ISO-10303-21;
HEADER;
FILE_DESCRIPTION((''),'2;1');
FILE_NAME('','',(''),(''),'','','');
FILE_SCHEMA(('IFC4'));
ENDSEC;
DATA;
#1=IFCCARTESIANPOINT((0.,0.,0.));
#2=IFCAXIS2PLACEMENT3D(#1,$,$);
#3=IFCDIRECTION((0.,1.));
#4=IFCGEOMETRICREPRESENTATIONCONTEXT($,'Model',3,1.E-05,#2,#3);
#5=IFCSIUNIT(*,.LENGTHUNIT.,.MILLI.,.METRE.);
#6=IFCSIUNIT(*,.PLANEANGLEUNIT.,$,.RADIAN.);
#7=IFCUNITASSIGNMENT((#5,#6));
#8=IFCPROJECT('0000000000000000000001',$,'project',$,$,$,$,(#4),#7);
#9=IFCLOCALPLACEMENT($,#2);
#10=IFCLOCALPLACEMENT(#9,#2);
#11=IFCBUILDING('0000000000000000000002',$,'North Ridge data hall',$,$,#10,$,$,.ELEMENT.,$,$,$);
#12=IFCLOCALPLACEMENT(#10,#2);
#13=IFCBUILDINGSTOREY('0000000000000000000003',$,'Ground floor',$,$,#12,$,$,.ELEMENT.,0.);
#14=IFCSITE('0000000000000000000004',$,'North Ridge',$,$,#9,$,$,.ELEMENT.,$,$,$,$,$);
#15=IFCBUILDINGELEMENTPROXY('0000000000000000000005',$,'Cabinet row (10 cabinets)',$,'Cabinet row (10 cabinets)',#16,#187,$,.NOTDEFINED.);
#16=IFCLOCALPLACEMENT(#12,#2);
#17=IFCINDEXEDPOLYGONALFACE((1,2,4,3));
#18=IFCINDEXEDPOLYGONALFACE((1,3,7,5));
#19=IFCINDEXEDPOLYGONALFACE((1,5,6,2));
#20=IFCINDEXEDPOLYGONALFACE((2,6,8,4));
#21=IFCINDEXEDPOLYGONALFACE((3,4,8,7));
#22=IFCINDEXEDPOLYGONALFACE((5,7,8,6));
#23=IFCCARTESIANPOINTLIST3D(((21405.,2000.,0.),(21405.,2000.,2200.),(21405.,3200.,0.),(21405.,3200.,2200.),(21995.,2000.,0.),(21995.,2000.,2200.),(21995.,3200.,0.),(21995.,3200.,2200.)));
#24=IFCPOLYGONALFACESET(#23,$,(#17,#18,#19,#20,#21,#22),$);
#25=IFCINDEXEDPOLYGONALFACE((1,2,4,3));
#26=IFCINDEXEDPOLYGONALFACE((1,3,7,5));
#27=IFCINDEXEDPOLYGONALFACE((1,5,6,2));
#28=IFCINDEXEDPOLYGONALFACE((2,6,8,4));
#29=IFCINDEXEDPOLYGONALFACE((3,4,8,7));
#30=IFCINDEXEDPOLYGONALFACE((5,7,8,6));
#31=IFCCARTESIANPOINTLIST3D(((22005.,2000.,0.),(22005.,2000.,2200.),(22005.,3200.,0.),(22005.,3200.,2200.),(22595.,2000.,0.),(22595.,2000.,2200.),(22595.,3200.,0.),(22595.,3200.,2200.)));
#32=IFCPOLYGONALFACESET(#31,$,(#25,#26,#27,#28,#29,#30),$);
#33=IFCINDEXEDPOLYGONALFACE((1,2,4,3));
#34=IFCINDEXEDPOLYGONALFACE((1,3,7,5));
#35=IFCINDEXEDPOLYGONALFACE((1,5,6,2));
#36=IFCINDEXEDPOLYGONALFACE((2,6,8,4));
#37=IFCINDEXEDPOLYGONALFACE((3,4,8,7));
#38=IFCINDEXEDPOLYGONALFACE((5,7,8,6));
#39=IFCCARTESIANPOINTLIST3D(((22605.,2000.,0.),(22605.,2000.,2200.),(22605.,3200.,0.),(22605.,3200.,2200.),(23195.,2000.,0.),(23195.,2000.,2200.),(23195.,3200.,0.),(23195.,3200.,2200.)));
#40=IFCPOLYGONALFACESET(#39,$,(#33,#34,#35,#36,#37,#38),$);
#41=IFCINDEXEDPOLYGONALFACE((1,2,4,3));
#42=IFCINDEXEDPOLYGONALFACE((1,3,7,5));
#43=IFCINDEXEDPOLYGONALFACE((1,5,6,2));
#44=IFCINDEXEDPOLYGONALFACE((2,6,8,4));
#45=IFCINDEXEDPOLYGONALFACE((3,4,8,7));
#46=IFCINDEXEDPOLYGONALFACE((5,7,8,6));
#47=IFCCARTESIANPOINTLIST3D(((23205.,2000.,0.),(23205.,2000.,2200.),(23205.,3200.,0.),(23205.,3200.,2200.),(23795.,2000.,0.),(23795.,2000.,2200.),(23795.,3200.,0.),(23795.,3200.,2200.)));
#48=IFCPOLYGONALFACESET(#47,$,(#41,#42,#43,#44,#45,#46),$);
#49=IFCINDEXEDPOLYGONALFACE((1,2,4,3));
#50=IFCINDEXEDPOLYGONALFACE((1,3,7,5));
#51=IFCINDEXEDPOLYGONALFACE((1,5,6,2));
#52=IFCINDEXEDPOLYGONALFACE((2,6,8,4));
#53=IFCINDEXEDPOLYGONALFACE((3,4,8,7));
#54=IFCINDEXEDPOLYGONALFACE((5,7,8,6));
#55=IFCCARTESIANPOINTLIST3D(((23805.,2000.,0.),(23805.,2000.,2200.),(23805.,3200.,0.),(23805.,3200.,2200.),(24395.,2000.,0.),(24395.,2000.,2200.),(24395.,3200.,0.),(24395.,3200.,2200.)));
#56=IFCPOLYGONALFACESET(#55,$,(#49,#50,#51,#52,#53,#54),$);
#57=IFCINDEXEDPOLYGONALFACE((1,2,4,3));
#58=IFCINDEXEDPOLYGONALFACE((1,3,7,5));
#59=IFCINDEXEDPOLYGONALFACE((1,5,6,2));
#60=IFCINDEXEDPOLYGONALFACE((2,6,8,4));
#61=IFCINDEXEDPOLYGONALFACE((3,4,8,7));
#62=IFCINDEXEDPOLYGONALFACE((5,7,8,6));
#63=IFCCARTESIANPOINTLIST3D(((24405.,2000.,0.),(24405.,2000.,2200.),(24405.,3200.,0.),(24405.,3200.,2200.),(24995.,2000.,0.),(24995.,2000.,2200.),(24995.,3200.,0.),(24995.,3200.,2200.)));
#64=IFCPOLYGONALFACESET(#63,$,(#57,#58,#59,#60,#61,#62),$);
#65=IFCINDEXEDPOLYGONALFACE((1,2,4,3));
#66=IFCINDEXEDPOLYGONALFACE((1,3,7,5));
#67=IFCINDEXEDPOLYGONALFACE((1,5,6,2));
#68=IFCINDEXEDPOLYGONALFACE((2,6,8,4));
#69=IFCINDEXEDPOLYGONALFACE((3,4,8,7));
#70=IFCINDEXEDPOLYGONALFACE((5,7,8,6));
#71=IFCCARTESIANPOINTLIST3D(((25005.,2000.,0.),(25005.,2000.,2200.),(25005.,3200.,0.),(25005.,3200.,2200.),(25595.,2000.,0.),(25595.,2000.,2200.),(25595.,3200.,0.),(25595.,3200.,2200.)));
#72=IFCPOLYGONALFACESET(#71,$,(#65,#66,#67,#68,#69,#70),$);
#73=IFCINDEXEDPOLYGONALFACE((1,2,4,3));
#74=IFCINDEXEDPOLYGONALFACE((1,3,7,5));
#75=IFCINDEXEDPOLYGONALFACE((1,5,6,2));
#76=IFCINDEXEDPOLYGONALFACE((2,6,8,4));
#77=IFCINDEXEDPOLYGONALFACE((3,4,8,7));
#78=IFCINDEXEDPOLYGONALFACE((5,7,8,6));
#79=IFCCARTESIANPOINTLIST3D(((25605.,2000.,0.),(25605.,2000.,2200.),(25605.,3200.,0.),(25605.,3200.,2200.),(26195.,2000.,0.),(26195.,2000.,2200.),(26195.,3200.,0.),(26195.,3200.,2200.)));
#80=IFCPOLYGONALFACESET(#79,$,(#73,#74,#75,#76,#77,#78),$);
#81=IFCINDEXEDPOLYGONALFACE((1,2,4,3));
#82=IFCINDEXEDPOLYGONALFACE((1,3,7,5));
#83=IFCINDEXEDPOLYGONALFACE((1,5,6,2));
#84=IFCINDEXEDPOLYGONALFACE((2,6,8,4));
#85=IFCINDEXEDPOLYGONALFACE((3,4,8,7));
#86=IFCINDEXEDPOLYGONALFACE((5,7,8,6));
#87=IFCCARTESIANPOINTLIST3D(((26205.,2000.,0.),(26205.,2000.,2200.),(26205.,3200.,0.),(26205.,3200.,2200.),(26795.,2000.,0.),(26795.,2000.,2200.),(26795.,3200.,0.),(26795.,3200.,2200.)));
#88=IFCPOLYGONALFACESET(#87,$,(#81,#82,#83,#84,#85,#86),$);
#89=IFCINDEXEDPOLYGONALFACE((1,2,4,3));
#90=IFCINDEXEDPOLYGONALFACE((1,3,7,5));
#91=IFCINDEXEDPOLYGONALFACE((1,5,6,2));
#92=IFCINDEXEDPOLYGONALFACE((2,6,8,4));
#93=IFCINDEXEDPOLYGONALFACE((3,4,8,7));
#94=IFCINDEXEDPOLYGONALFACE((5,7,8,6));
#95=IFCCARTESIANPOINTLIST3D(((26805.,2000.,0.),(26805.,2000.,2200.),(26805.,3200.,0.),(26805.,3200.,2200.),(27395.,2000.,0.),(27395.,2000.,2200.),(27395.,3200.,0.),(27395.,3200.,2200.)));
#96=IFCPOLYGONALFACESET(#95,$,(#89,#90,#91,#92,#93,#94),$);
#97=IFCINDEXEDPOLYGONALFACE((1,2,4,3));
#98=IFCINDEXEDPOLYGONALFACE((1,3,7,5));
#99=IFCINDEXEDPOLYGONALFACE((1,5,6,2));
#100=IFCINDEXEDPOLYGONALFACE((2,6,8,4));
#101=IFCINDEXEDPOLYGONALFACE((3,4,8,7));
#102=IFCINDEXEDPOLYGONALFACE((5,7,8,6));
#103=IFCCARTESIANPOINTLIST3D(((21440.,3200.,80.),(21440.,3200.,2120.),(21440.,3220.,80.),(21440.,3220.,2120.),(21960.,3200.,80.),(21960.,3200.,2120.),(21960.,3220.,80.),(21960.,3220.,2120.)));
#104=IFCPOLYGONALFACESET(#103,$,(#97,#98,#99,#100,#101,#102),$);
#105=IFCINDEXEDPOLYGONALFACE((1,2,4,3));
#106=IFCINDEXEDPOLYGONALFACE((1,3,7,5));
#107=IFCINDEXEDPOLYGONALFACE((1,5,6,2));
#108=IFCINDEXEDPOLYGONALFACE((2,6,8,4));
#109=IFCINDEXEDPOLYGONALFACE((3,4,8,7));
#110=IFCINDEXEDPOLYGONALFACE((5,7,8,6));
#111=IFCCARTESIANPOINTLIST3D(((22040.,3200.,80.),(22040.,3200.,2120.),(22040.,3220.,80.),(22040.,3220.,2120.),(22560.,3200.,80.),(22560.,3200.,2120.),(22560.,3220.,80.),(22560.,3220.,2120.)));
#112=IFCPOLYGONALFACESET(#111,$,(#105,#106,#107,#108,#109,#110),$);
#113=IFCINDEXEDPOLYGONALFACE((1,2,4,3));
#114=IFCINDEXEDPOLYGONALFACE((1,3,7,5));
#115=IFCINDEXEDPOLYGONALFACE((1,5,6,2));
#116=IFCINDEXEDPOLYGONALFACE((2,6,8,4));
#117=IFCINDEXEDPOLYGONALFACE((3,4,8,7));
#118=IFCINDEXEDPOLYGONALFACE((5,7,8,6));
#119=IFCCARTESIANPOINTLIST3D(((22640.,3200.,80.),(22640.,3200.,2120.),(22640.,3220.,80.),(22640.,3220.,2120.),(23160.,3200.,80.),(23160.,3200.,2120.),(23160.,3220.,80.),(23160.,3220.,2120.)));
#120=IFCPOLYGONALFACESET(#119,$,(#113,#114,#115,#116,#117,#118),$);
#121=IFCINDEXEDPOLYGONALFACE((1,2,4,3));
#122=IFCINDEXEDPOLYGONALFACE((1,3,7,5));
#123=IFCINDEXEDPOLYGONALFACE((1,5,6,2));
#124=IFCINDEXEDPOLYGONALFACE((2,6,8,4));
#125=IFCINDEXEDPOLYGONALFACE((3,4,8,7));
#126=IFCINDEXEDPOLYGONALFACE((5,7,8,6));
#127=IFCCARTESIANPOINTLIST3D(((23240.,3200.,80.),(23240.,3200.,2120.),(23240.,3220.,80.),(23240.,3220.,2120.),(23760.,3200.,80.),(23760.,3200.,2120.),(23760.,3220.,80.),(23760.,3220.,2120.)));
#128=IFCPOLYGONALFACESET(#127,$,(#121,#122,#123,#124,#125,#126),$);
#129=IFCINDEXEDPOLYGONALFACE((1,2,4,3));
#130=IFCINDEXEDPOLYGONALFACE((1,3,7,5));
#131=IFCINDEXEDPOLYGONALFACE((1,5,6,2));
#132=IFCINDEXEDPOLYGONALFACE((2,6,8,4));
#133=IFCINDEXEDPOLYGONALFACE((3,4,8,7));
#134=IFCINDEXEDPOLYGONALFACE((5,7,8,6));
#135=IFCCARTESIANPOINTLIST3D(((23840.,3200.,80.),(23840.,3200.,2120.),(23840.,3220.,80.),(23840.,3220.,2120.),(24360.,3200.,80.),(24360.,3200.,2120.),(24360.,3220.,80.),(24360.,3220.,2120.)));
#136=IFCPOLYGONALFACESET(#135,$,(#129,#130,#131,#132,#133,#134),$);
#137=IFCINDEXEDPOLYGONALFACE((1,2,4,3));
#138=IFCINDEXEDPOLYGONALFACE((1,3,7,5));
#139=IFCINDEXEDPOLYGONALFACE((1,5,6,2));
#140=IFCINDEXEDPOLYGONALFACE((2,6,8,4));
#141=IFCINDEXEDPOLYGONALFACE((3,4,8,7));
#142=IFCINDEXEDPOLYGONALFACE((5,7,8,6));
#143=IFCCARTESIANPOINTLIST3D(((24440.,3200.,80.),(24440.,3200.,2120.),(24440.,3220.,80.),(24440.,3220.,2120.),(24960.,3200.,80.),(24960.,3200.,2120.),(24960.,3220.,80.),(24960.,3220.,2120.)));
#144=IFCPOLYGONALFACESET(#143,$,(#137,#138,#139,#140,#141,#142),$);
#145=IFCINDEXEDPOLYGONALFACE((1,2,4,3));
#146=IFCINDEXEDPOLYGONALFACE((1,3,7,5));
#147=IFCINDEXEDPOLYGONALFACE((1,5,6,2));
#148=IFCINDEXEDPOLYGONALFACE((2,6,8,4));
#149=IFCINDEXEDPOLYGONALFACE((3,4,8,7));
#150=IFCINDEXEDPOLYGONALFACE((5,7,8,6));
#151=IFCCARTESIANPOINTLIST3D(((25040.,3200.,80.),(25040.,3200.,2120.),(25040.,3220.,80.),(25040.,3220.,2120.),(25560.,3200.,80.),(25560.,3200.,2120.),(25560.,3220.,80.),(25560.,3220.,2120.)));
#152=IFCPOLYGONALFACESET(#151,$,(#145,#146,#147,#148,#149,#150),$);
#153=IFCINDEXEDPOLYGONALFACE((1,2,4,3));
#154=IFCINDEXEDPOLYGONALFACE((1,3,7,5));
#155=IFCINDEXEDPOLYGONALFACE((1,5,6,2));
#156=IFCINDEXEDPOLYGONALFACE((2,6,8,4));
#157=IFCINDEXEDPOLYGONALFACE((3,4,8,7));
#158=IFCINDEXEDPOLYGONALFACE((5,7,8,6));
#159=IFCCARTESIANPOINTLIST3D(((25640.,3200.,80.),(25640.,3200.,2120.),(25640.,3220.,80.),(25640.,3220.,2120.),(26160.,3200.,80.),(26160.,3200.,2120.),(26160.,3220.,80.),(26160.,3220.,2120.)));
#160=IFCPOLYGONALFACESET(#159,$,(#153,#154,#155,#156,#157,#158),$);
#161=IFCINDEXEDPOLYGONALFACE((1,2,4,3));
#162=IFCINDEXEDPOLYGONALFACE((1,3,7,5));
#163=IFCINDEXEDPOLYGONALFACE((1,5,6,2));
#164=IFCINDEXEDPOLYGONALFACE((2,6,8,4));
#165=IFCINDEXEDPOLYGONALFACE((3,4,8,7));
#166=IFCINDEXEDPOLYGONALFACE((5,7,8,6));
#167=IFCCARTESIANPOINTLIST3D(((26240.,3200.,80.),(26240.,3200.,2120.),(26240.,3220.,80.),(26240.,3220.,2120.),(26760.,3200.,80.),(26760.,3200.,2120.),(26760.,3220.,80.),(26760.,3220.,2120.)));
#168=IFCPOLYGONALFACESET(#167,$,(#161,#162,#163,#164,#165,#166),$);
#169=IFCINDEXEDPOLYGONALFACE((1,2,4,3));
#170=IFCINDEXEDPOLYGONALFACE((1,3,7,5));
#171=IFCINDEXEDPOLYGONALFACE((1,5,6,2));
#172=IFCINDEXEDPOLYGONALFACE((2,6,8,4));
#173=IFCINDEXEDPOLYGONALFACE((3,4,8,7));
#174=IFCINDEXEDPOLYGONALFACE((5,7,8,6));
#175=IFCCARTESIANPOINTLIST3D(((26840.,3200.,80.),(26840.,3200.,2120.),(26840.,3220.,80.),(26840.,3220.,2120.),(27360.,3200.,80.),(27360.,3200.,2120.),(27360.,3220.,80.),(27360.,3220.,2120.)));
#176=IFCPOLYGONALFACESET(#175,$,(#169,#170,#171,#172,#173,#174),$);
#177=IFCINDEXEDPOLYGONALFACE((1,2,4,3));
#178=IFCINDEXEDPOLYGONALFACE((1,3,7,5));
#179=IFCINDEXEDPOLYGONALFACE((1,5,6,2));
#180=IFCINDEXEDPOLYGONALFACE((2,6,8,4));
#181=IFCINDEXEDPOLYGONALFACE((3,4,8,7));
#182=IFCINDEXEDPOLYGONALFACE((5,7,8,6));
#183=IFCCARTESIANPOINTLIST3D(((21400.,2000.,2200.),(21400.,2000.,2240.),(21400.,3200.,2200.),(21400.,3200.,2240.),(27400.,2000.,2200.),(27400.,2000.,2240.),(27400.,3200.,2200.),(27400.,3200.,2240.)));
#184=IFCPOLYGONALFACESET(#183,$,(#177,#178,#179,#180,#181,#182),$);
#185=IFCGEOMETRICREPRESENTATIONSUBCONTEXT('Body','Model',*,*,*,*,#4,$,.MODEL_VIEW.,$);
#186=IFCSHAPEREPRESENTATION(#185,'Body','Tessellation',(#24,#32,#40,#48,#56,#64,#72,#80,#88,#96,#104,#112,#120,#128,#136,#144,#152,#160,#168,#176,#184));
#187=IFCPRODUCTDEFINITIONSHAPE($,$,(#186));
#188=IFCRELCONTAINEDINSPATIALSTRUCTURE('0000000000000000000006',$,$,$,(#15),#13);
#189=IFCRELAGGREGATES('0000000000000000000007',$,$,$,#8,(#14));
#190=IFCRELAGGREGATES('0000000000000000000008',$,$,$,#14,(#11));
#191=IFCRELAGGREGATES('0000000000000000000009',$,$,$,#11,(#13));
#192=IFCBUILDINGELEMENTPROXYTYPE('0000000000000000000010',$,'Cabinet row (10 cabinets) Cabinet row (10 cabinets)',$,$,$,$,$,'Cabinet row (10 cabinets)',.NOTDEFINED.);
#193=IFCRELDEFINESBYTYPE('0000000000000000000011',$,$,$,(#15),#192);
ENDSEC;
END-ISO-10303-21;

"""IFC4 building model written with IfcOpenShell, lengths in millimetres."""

from ifc_helpers import new_model, si_unit, direction, frame, origin, place, context, subcontext, project, spatial, polyline, outline, extrude, source, transform, mapped, type_object, type_shapes, element, save


model = new_model("IFC4")

# Units and contexts
model_context = context("Model", 3, precision=1e-05, world=origin(), true_north=direction((0.0, 1.0)))
body_context = subcontext(model_context, "Body", "Model", "MODEL_VIEW")
ifc_project = project(units=[si_unit("LENGTHUNIT", "METRE", prefix="MILLI"), si_unit("PLANEANGLEUNIT", "RADIAN")], contexts=[model_context])

# Site, building, storey
site_placement = place(None, origin())
site = spatial("IfcSite", under=ifc_project, at=site_placement, Name="North Ridge", CompositionType="ELEMENT")
building_placement = place(site_placement, origin())
building = spatial("IfcBuilding", under=site, at=building_placement, Name="North Ridge data hall", CompositionType="ELEMENT")
storey_placement = place(building_placement, origin())
storey = spatial("IfcBuildingStorey", under=building, at=storey_placement, Name="Ground floor", CompositionType="ELEMENT", Elevation=0.0)

# Building element proxy
building_element_proxy_type_1 = type_object("IfcBuildingElementProxyType", Name="Cabinet row (10 cabinets) Cabinet row (10 cabinets)", ElementType="Cabinet row (10 cabinets)", PredefinedType="NOTDEFINED")
shared_shape_1 = source(origin(), body_context, "Body", "SweptSolid", [
    extrude(outline(polyline([(5.0, 0.0), (595.0, 0.0), (595.0, 1200.0), (5.0, 1200.0), (5.0, 0.0)])), origin(), (0.0, 0.0, 1.0), 2200.0),
    extrude(outline(polyline([(605.0, 0.0), (1195.0, 0.0), (1195.0, 1200.0), (605.0, 1200.0), (605.0, 0.0)])), origin(), (0.0, 0.0, 1.0), 2200.0),
    extrude(outline(polyline([(1205.0, 0.0), (1795.0, 0.0), (1795.0, 1200.0), (1205.0, 1200.0), (1205.0, 0.0)])), origin(), (0.0, 0.0, 1.0), 2200.0),
    extrude(outline(polyline([(1805.0, 0.0), (2395.0, 0.0), (2395.0, 1200.0), (1805.0, 1200.0), (1805.0, 0.0)])), origin(), (0.0, 0.0, 1.0), 2200.0),
    extrude(outline(polyline([(2405.0, 0.0), (2995.0, 0.0), (2995.0, 1200.0), (2405.0, 1200.0), (2405.0, 0.0)])), origin(), (0.0, 0.0, 1.0), 2200.0),
    extrude(outline(polyline([(3005.0, 0.0), (3595.0, 0.0), (3595.0, 1200.0), (3005.0, 1200.0), (3005.0, 0.0)])), origin(), (0.0, 0.0, 1.0), 2200.0),
    extrude(outline(polyline([(3605.0, 0.0), (4195.0, 0.0), (4195.0, 1200.0), (3605.0, 1200.0), (3605.0, 0.0)])), origin(), (0.0, 0.0, 1.0), 2200.0),
    extrude(outline(polyline([(4205.0, 0.0), (4795.0, 0.0), (4795.0, 1200.0), (4205.0, 1200.0), (4205.0, 0.0)])), origin(), (0.0, 0.0, 1.0), 2200.0),
    extrude(outline(polyline([(4805.0, 0.0), (5395.0, 0.0), (5395.0, 1200.0), (4805.0, 1200.0), (4805.0, 0.0)])), origin(), (0.0, 0.0, 1.0), 2200.0),
    extrude(outline(polyline([(5405.0, 0.0), (5995.0, 0.0), (5995.0, 1200.0), (5405.0, 1200.0), (5405.0, 0.0)])), origin(), (0.0, 0.0, 1.0), 2200.0),
    extrude(outline(polyline([(40.0, 1200.0), (560.0, 1200.0), (560.0, 1220.0), (40.0, 1220.0), (40.0, 1200.0)])), frame((0.0, 0.0, 80.0)), (0.0, 0.0, 1.0), 2040.0),
    extrude(outline(polyline([(640.0, 1200.0), (1160.0, 1200.0), (1160.0, 1220.0), (640.0, 1220.0), (640.0, 1200.0)])), frame((0.0, 0.0, 80.0)), (0.0, 0.0, 1.0), 2040.0),
    extrude(outline(polyline([(1240.0, 1200.0), (1760.0, 1200.0), (1760.0, 1220.0), (1240.0, 1220.0), (1240.0, 1200.0)])), frame((0.0, 0.0, 80.0)), (0.0, 0.0, 1.0), 2040.0),
    extrude(outline(polyline([(1840.0, 1200.0), (2360.0, 1200.0), (2360.0, 1220.0), (1840.0, 1220.0), (1840.0, 1200.0)])), frame((0.0, 0.0, 80.0)), (0.0, 0.0, 1.0), 2040.0),
    extrude(outline(polyline([(2440.0, 1200.0), (2960.0, 1200.0), (2960.0, 1220.0), (2440.0, 1220.0), (2440.0, 1200.0)])), frame((0.0, 0.0, 80.0)), (0.0, 0.0, 1.0), 2040.0),
    extrude(outline(polyline([(3040.0, 1200.0), (3560.0, 1200.0), (3560.0, 1220.0), (3040.0, 1220.0), (3040.0, 1200.0)])), frame((0.0, 0.0, 80.0)), (0.0, 0.0, 1.0), 2040.0),
    extrude(outline(polyline([(3640.0, 1200.0), (4160.0, 1200.0), (4160.0, 1220.0), (3640.0, 1220.0), (3640.0, 1200.0)])), frame((0.0, 0.0, 80.0)), (0.0, 0.0, 1.0), 2040.0),
    extrude(outline(polyline([(4240.0, 1200.0), (4760.0, 1200.0), (4760.0, 1220.0), (4240.0, 1220.0), (4240.0, 1200.0)])), frame((0.0, 0.0, 80.0)), (0.0, 0.0, 1.0), 2040.0),
    extrude(outline(polyline([(4840.0, 1200.0), (5360.0, 1200.0), (5360.0, 1220.0), (4840.0, 1220.0), (4840.0, 1200.0)])), frame((0.0, 0.0, 80.0)), (0.0, 0.0, 1.0), 2040.0),
    extrude(outline(polyline([(5440.0, 1200.0), (5960.0, 1200.0), (5960.0, 1220.0), (5440.0, 1220.0), (5440.0, 1200.0)])), frame((0.0, 0.0, 80.0)), (0.0, 0.0, 1.0), 2040.0),
    extrude(outline(polyline([(0.0, 0.0), (6000.0, 0.0), (6000.0, 1200.0), (0.0, 1200.0), (0.0, 0.0)])), frame((0.0, 0.0, 2200.0)), (0.0, 0.0, 1.0), 40.0),
])
type_shapes(building_element_proxy_type_1, [shared_shape_1])
for number, where, z_axis, x_axis, name in (
    (1, (21400.0, 2000.0, 0.0), (0.0, 0.0, 1.0), (1.0, 0.0, 0.0), "Cabinet row (10 cabinets)"),
):
    element("IfcBuildingElementProxy", number, at=place(storey_placement, frame(where, z_axis=z_axis, x_axis=x_axis)), inside=storey, type_object=building_element_proxy_type_1, Name=name, ObjectType="Cabinet row (10 cabinets)", PredefinedType="NOTDEFINED", context=body_context, shape_type="MappedRepresentation", body=[
        mapped(shared_shape_1, transform((0.0, 0.0, 0.0))),
    ])

save(model, "model.ifc")
